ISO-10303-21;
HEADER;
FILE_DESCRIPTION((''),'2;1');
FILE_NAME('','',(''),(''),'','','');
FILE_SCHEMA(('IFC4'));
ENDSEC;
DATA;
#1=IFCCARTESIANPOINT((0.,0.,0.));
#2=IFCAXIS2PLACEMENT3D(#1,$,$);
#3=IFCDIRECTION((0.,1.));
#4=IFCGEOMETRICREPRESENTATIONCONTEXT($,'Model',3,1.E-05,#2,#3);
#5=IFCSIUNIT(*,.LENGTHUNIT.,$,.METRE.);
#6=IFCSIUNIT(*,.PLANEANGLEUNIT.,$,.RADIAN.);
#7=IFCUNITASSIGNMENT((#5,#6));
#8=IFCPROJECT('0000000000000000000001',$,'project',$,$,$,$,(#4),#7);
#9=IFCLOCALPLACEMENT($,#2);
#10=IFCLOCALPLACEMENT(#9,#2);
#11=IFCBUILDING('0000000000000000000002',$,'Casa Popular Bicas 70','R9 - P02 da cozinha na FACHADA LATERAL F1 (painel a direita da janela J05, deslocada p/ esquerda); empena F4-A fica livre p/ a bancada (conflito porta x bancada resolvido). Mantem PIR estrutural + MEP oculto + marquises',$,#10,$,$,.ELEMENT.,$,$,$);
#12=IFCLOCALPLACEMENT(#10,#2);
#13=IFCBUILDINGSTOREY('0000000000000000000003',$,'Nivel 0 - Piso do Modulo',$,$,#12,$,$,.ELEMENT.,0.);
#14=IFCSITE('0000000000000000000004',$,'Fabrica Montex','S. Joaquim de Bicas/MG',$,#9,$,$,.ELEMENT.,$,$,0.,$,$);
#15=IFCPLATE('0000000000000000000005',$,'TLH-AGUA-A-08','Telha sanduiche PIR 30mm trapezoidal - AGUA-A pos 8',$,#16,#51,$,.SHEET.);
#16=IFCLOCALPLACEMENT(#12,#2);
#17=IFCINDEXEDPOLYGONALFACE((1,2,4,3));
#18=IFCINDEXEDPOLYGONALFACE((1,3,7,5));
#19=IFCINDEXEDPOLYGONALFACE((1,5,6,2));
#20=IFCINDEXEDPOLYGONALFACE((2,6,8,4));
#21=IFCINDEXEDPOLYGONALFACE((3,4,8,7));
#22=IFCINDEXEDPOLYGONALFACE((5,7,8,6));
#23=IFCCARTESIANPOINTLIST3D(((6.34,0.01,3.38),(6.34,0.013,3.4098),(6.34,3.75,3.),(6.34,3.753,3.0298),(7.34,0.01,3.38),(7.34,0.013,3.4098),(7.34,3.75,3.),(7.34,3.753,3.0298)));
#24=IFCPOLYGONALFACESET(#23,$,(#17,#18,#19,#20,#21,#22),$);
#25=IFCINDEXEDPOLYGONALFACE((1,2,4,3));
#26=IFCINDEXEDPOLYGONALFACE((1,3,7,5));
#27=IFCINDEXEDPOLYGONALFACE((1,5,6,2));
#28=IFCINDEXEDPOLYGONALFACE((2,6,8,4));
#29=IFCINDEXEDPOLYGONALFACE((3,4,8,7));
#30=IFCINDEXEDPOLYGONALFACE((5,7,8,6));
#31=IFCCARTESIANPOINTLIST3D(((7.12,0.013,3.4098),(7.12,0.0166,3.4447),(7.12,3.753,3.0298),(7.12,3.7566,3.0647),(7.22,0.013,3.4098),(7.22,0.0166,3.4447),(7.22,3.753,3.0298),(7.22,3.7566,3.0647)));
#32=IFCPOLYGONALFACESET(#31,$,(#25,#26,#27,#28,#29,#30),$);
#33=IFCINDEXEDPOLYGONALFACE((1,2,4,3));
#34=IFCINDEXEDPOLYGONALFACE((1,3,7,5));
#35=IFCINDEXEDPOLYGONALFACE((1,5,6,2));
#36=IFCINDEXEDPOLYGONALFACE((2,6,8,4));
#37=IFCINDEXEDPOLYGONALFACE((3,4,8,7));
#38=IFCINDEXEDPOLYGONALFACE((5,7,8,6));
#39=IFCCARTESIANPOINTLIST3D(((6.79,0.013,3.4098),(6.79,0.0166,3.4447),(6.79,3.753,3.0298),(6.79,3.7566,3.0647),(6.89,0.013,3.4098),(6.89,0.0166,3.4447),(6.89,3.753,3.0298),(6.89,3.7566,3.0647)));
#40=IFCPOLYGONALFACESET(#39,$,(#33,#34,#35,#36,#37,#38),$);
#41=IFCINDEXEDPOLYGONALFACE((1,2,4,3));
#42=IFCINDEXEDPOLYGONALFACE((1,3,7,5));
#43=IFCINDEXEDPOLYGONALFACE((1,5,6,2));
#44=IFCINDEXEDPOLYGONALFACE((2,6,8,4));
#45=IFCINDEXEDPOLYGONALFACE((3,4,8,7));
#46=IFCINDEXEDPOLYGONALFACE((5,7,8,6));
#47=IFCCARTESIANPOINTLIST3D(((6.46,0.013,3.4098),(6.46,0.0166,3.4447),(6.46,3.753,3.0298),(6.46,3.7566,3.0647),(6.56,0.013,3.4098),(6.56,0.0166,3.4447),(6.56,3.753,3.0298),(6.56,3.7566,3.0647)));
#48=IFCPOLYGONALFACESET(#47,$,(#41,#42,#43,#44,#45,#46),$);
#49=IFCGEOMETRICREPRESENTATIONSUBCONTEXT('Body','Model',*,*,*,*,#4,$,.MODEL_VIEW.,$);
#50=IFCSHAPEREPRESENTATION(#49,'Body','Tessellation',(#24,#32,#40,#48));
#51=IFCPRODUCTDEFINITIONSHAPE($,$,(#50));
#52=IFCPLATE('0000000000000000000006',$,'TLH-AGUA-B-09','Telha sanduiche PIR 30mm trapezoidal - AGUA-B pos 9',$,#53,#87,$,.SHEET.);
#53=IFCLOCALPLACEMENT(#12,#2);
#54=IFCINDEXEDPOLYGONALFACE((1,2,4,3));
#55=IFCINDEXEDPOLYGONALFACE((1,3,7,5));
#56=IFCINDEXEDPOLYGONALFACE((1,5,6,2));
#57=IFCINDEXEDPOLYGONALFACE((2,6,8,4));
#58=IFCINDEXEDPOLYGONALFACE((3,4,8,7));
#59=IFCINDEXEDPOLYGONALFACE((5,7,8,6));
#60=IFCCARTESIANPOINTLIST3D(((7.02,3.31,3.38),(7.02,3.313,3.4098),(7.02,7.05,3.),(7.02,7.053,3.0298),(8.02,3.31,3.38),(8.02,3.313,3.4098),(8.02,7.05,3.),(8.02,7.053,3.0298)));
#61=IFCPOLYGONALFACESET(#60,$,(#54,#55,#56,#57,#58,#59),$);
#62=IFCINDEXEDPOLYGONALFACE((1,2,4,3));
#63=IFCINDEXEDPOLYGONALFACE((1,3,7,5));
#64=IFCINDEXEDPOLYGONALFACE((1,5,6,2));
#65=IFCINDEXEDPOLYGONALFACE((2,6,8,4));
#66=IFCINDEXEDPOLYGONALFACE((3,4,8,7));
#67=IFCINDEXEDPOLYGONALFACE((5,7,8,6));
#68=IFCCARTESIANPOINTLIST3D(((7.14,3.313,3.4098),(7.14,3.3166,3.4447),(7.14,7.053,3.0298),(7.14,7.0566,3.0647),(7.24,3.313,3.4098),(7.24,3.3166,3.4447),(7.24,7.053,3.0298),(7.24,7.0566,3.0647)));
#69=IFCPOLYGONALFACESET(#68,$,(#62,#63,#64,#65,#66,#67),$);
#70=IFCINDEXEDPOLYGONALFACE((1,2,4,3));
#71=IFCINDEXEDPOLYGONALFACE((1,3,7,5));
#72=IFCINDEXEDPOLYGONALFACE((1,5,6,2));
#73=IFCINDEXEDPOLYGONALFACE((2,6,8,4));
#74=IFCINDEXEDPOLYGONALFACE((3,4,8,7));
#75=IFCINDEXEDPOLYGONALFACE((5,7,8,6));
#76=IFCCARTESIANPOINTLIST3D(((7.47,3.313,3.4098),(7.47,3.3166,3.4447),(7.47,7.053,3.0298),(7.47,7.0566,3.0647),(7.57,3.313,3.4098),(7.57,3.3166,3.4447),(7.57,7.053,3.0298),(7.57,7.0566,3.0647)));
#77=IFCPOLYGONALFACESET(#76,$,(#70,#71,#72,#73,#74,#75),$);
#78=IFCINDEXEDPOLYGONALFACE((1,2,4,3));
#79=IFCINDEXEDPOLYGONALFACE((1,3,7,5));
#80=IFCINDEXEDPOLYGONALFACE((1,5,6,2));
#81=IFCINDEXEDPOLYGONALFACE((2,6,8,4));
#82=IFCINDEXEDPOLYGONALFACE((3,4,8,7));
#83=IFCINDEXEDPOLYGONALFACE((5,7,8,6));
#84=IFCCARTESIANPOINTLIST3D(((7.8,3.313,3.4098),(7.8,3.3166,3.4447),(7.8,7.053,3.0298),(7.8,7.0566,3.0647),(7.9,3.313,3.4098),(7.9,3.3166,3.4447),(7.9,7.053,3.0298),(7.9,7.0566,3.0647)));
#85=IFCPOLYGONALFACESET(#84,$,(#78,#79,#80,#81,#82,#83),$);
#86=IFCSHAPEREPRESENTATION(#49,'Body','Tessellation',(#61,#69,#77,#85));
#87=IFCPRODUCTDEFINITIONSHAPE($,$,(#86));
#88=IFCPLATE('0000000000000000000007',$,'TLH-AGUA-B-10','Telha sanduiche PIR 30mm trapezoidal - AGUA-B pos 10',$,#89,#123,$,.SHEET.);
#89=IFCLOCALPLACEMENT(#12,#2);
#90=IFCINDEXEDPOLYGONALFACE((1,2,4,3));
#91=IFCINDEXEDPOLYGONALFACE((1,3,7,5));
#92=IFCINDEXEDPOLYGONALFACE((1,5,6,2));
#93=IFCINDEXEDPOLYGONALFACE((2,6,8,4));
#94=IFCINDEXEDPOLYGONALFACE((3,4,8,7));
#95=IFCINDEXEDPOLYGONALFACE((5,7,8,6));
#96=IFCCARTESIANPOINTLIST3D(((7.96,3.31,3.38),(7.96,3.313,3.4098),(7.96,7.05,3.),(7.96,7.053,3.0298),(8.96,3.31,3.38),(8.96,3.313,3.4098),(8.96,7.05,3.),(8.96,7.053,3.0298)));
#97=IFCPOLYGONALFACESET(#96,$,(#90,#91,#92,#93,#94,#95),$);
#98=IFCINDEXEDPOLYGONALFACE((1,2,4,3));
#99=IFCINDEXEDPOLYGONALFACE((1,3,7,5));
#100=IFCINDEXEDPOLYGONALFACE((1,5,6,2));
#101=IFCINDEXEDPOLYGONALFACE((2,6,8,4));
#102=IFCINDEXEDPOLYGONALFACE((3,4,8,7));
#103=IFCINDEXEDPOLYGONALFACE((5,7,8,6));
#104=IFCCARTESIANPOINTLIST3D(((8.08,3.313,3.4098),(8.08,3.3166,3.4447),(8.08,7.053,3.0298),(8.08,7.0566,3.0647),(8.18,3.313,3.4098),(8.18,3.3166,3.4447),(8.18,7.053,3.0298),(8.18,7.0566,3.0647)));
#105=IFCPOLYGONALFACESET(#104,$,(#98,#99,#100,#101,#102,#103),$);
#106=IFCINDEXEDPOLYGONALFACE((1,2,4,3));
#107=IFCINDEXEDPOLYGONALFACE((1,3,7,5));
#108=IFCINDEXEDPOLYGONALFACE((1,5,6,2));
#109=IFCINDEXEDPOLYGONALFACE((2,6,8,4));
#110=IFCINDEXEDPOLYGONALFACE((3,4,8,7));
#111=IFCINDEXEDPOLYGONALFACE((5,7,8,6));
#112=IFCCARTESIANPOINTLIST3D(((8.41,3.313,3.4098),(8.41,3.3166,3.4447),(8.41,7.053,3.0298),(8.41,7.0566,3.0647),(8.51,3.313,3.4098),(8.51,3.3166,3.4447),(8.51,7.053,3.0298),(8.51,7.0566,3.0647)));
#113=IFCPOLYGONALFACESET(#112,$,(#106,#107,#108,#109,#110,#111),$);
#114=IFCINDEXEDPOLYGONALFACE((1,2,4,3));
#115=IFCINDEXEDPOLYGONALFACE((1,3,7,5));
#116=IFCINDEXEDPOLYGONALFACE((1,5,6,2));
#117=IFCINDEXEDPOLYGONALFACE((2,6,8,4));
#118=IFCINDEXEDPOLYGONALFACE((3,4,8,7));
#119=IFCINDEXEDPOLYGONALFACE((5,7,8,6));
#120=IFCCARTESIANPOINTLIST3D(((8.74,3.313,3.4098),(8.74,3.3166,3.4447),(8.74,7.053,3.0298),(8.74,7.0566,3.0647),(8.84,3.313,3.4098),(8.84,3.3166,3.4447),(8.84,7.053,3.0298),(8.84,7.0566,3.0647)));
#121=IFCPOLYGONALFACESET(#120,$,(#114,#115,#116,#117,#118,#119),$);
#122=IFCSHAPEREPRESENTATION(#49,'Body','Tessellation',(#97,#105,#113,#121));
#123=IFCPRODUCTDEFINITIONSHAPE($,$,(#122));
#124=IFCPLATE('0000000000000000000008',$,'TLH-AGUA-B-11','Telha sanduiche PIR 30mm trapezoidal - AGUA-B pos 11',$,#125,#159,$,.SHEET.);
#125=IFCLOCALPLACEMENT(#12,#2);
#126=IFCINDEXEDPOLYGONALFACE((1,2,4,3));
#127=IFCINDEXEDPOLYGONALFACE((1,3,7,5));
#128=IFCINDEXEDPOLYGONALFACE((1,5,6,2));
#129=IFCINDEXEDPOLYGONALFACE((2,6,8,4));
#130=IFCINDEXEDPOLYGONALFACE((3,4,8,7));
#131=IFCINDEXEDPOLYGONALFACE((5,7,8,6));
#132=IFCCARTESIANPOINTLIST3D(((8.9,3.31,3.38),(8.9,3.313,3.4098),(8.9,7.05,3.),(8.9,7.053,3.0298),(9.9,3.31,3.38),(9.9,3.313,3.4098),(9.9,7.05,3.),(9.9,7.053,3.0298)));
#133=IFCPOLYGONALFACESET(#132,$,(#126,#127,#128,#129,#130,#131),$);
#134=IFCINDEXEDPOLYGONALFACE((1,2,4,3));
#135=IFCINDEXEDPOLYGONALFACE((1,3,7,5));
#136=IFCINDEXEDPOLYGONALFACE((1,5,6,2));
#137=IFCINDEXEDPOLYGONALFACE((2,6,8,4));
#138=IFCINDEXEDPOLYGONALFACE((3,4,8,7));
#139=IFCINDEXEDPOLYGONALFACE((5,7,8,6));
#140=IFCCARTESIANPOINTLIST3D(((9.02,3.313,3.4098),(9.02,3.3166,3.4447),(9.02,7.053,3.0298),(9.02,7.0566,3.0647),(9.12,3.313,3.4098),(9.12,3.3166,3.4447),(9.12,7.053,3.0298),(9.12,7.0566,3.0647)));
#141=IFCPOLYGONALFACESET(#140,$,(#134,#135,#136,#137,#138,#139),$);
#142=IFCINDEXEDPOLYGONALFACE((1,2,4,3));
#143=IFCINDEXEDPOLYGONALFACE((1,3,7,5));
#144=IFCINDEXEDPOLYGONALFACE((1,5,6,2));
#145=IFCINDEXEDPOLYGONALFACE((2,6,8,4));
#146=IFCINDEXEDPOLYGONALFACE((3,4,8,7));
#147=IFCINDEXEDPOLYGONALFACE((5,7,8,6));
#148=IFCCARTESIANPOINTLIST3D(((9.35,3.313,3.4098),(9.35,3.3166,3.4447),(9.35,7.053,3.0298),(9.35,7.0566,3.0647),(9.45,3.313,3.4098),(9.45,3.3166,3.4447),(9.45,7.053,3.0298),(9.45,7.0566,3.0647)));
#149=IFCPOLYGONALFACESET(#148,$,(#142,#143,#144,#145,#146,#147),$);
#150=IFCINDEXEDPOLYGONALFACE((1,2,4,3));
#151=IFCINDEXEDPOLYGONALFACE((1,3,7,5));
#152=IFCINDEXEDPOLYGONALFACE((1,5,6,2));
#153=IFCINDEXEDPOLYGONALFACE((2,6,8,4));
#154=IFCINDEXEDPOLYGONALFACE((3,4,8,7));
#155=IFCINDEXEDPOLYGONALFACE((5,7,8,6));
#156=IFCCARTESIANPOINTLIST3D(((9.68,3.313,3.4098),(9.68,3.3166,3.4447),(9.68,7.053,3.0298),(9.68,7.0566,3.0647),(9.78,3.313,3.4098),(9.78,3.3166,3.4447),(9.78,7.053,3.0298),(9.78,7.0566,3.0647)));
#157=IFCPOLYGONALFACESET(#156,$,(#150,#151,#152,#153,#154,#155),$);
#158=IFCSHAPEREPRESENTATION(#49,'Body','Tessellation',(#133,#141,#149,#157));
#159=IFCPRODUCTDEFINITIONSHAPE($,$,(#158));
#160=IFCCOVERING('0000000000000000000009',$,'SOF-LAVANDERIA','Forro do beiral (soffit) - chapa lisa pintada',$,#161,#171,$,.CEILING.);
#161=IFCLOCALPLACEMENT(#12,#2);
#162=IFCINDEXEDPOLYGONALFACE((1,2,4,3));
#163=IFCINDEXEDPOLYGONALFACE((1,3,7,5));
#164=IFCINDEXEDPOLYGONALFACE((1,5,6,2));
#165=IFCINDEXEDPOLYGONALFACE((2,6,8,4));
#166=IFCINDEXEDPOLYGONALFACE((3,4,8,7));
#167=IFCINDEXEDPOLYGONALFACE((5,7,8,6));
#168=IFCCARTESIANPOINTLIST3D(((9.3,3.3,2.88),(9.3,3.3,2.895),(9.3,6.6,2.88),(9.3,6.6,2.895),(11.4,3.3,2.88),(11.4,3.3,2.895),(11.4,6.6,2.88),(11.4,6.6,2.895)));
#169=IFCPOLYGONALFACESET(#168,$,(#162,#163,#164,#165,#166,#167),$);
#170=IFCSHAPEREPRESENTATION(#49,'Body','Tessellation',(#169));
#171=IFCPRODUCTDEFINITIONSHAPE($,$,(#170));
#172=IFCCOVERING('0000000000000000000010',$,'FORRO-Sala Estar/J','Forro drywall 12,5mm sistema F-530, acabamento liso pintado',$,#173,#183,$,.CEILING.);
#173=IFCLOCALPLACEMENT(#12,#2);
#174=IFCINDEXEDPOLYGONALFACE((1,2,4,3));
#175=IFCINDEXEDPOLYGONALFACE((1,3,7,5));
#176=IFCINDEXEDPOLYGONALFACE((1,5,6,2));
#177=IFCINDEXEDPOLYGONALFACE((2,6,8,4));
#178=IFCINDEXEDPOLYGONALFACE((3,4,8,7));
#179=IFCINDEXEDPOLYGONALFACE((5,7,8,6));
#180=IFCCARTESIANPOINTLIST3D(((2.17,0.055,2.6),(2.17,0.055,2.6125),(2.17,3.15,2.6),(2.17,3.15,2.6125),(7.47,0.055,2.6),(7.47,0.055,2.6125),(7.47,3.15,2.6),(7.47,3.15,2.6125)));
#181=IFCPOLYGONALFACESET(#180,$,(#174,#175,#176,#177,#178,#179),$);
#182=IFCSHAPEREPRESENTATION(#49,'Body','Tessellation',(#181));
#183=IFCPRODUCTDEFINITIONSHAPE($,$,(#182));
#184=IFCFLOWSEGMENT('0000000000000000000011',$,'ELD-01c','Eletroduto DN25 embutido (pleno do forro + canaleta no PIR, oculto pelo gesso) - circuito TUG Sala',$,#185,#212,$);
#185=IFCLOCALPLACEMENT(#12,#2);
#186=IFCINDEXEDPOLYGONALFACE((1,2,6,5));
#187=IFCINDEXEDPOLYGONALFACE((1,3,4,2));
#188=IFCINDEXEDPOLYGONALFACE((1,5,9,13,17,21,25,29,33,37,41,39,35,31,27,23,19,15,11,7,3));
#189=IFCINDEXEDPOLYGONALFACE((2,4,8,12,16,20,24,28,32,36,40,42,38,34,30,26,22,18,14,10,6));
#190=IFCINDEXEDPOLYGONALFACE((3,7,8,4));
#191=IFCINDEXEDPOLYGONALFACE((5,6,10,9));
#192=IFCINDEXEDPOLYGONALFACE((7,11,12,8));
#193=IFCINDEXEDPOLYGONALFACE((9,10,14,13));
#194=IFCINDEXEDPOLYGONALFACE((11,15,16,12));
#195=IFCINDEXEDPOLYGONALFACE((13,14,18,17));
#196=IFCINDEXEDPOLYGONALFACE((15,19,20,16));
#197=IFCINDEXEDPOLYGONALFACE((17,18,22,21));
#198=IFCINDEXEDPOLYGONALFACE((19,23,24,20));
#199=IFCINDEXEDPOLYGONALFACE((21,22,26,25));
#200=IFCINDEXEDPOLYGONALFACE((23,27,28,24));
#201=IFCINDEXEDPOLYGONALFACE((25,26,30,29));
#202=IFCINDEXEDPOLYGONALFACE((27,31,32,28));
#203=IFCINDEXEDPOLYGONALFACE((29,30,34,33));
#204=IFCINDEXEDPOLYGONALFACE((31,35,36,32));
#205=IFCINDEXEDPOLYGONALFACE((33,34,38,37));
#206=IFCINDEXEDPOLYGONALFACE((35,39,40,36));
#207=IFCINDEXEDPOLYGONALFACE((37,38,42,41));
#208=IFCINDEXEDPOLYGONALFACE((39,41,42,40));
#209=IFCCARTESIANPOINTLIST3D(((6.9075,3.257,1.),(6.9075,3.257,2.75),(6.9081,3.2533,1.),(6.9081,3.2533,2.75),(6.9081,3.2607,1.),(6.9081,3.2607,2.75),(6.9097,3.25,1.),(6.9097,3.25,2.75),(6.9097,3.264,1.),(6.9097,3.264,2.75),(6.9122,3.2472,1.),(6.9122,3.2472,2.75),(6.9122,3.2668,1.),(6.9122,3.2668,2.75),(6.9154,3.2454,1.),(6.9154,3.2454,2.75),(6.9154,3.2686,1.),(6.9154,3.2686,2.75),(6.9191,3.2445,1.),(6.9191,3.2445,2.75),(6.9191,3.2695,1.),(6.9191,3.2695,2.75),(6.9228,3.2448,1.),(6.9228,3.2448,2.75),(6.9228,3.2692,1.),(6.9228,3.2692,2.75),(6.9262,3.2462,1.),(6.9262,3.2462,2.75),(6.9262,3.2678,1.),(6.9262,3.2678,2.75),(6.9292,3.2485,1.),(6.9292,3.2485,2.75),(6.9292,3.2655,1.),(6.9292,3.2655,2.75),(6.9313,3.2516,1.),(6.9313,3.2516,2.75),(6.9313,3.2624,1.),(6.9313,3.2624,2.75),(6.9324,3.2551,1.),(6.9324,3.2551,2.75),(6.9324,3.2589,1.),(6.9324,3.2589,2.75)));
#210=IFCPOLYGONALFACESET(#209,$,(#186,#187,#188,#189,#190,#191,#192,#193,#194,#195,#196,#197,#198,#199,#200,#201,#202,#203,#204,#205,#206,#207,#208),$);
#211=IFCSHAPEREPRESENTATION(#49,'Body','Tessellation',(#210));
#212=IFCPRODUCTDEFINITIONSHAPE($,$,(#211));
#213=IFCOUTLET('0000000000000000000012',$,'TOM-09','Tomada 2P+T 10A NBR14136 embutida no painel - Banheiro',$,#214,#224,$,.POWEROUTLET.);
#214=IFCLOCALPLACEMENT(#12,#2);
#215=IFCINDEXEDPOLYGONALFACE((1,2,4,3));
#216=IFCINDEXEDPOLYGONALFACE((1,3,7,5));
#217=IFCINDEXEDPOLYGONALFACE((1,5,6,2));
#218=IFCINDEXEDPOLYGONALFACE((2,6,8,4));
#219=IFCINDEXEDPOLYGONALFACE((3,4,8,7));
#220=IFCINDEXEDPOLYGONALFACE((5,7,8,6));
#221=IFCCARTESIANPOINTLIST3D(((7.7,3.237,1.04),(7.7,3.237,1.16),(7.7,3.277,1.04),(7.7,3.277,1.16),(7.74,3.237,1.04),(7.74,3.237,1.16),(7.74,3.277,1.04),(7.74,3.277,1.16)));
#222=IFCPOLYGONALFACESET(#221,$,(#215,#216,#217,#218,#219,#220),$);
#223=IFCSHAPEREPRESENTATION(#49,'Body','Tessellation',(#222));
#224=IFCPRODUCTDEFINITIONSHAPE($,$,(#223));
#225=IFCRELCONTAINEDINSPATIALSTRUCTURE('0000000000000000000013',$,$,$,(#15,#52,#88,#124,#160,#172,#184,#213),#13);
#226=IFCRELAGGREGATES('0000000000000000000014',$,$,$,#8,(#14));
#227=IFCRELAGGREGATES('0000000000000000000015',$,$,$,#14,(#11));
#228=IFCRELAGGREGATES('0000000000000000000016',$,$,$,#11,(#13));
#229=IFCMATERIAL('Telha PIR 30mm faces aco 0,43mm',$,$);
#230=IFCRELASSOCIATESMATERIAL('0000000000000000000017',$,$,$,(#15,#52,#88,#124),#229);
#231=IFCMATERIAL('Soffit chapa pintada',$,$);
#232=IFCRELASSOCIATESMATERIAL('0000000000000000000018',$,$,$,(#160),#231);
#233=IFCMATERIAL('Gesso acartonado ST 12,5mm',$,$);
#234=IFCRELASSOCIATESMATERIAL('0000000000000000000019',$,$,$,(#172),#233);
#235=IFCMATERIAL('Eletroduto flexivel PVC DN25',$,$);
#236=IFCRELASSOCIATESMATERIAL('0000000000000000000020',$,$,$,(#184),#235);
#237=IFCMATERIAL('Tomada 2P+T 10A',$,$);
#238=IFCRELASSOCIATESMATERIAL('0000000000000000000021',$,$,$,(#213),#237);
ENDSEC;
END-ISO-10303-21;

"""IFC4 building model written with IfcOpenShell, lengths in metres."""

from ifc_helpers import new_model, si_unit, direction, frame, frame_2d, origin, origin_2d, place, context, subcontext, project, spatial, rectangle, circle, extrude, material, element, save


model = new_model("IFC4")

# Units and contexts
model_context = context("Model", 3, precision=1e-05, world=origin(), true_north=direction((0.0, 1.0)))
body_context = subcontext(model_context, "Body", "Model", "MODEL_VIEW")
ifc_project = project(units=[si_unit("LENGTHUNIT", "METRE"), si_unit("PLANEANGLEUNIT", "RADIAN")], contexts=[model_context])

# Site, building, storey
site_placement = place(None, origin())
site = spatial("IfcSite", under=ifc_project, at=site_placement, Name="Fabrica Montex", Description="S. Joaquim de Bicas/MG", CompositionType="ELEMENT", RefElevation=0.0)
building_placement = place(site_placement, origin())
building = spatial("IfcBuilding", under=site, at=building_placement, Name="Casa Popular Bicas 70", Description="R9 - P02 da cozinha na FACHADA LATERAL F1 (painel a direita da janela J05, deslocada p/ esquerda); empena F4-A fica livre p/ a bancada (conflito porta x bancada resolvido). Mantem PIR estrutural + MEP oculto + marquises", CompositionType="ELEMENT")
storey_placement = place(building_placement, origin())
storey = spatial("IfcBuildingStorey", under=building, at=storey_placement, Name="Nivel 0 - Piso do Modulo", CompositionType="ELEMENT", Elevation=0.0)

# Plates
ifc_material_1 = material(Name="Telha PIR 30mm faces aco 0,43mm")
for number, where, z_axis, x_axis, name in (
    (1, (7.34, 3.75, 3.0), (0.0, 0.101084, 0.994878), (-1.0, 0.0, 0.0), "TLH-AGUA-A-08"),
):
    element("IfcPlate", number, at=place(None, frame(where, z_axis=z_axis, x_axis=x_axis)), inside=storey, material=ifc_material_1, Name=name, Description="Telha sanduiche PIR 30mm trapezoidal - AGUA-A pos 8", PredefinedType="SHEET", context=body_context, shape_type="SweptSolid", body=[
        extrude(rectangle(XDim=1.0, YDim=3.7593, at=frame_2d((0.5, 1.8796))), origin(), (0.0, 0.0, 1.0), 0.03),
        extrude(rectangle(XDim=0.1, YDim=3.7593, at=frame_2d((0.17, 1.8796))), frame((0.0, 0.0, 0.03)), (0.0, 0.0, 1.0), 0.035),
        extrude(rectangle(XDim=0.1, YDim=3.7593, at=frame_2d((0.5, 1.8796))), frame((0.0, 0.0, 0.03)), (0.0, 0.0, 1.0), 0.035),
        extrude(rectangle(XDim=0.1, YDim=3.7593, at=frame_2d((0.83, 1.8796))), frame((0.0, 0.0, 0.03)), (0.0, 0.0, 1.0), 0.035),
    ])
for number, where, z_axis, x_axis, name, description in (
    (2, (7.02, 3.31, 3.38), (0.0, 0.101084, 0.994878), (1.0, 0.0, 0.0), "TLH-AGUA-B-09", "Telha sanduiche PIR 30mm trapezoidal - AGUA-B pos 9"),
    (3, (7.96, 3.31, 3.38), (0.0, 0.101084, 0.994878), (1.0, 0.0, 0.0), "TLH-AGUA-B-10", "Telha sanduiche PIR 30mm trapezoidal - AGUA-B pos 10"),
    (4, (8.9, 3.31, 3.38), (0.0, 0.101084, 0.994878), (1.0, 0.0, 0.0), "TLH-AGUA-B-11", "Telha sanduiche PIR 30mm trapezoidal - AGUA-B pos 11"),
):
    element("IfcPlate", number, at=place(storey_placement, frame(where, z_axis=z_axis, x_axis=x_axis)), inside=storey, material=ifc_material_1, Name=name, Description=description, PredefinedType="SHEET", context=body_context, shape_type="SweptSolid", body=[
        extrude(rectangle(XDim=1.0, YDim=3.7593, at=frame_2d((0.5, 1.8796))), origin(), (0.0, 0.0, 1.0), 0.03),
        extrude(rectangle(XDim=0.1, YDim=3.7593, at=frame_2d((0.17, 1.8796))), frame((0.0, 0.0, 0.03)), (0.0, 0.0, 1.0), 0.035),
        extrude(rectangle(XDim=0.1, YDim=3.7593, at=frame_2d((0.5, 1.8796))), frame((0.0, 0.0, 0.03)), (0.0, 0.0, 1.0), 0.035),
        extrude(rectangle(XDim=0.1, YDim=3.7593, at=frame_2d((0.83, 1.8796))), frame((0.0, 0.0, 0.03)), (0.0, 0.0, 1.0), 0.035),
    ])

# Coverings
ifc_material_2 = material(Name="Soffit chapa pintada")
covering_1_placement = place(storey_placement, frame((9.3, 3.3, 2.88)))
element("IfcCovering", 5, at=covering_1_placement, inside=storey, material=ifc_material_2, Name="SOF-LAVANDERIA", Description="Forro do beiral (soffit) - chapa lisa pintada", PredefinedType="CEILING", context=body_context, shape_type="SweptSolid", body=[
    extrude(rectangle(XDim=2.1, YDim=3.3, at=frame_2d((1.05, 1.65))), origin(), (0.0, 0.0, 1.0), 0.015),
])
ifc_material_3 = material(Name="Gesso acartonado ST 12,5mm")
covering_2_placement = place(None, frame((7.47, 3.15, 2.6), z_axis=(0.0, 0.0, 1.0), x_axis=(-1.0, 0.0, 0.0)))
element("IfcCovering", 6, at=covering_2_placement, inside=storey, material=ifc_material_3, Name="FORRO-Sala Estar/J", Description="Forro drywall 12,5mm sistema F-530, acabamento liso pintado", PredefinedType="CEILING", context=body_context, shape_type="SweptSolid", body=[
    extrude(rectangle(XDim=5.3, YDim=3.095, at=frame_2d((2.65, 1.5475))), origin(), (0.0, 0.0, 1.0), 0.0125),
])

# Flow segment
ifc_material_4 = material(Name="Eletroduto flexivel PVC DN25")
flow_segment_1_placement = place(None, frame((6.92, 3.257, 2.75), z_axis=(0.0, 0.0, -1.0), x_axis=(-1.0, 0.0, 0.0)))
element("IfcFlowSegment", 7, at=flow_segment_1_placement, inside=storey, material=ifc_material_4, Name="ELD-01c", Description="Eletroduto DN25 embutido (pleno do forro + canaleta no PIR, oculto pelo gesso) - circuito TUG Sala", context=body_context, shape_type="SweptSolid", body=[
    extrude(circle(Radius=0.0125, at=origin_2d()), origin(), (0.0, 0.0, 1.0), 1.75),
])

# Outlet
ifc_material_5 = material(Name="Tomada 2P+T 10A")
outlet_1_placement = place(None, frame((7.74, 3.277, 1.04), z_axis=(0.0, 0.0, 1.0), x_axis=(-1.0, 0.0, 0.0)))
element("IfcOutlet", 8, at=outlet_1_placement, inside=storey, material=ifc_material_5, Name="TOM-09", Description="Tomada 2P+T 10A NBR14136 embutida no painel - Banheiro", PredefinedType="POWEROUTLET", context=body_context, shape_type="SweptSolid", body=[
    extrude(rectangle(XDim=0.04, YDim=0.04, at=frame_2d((0.02, 0.02))), origin(), (0.0, 0.0, 1.0), 0.12),
])

save(model, "model.ifc")
